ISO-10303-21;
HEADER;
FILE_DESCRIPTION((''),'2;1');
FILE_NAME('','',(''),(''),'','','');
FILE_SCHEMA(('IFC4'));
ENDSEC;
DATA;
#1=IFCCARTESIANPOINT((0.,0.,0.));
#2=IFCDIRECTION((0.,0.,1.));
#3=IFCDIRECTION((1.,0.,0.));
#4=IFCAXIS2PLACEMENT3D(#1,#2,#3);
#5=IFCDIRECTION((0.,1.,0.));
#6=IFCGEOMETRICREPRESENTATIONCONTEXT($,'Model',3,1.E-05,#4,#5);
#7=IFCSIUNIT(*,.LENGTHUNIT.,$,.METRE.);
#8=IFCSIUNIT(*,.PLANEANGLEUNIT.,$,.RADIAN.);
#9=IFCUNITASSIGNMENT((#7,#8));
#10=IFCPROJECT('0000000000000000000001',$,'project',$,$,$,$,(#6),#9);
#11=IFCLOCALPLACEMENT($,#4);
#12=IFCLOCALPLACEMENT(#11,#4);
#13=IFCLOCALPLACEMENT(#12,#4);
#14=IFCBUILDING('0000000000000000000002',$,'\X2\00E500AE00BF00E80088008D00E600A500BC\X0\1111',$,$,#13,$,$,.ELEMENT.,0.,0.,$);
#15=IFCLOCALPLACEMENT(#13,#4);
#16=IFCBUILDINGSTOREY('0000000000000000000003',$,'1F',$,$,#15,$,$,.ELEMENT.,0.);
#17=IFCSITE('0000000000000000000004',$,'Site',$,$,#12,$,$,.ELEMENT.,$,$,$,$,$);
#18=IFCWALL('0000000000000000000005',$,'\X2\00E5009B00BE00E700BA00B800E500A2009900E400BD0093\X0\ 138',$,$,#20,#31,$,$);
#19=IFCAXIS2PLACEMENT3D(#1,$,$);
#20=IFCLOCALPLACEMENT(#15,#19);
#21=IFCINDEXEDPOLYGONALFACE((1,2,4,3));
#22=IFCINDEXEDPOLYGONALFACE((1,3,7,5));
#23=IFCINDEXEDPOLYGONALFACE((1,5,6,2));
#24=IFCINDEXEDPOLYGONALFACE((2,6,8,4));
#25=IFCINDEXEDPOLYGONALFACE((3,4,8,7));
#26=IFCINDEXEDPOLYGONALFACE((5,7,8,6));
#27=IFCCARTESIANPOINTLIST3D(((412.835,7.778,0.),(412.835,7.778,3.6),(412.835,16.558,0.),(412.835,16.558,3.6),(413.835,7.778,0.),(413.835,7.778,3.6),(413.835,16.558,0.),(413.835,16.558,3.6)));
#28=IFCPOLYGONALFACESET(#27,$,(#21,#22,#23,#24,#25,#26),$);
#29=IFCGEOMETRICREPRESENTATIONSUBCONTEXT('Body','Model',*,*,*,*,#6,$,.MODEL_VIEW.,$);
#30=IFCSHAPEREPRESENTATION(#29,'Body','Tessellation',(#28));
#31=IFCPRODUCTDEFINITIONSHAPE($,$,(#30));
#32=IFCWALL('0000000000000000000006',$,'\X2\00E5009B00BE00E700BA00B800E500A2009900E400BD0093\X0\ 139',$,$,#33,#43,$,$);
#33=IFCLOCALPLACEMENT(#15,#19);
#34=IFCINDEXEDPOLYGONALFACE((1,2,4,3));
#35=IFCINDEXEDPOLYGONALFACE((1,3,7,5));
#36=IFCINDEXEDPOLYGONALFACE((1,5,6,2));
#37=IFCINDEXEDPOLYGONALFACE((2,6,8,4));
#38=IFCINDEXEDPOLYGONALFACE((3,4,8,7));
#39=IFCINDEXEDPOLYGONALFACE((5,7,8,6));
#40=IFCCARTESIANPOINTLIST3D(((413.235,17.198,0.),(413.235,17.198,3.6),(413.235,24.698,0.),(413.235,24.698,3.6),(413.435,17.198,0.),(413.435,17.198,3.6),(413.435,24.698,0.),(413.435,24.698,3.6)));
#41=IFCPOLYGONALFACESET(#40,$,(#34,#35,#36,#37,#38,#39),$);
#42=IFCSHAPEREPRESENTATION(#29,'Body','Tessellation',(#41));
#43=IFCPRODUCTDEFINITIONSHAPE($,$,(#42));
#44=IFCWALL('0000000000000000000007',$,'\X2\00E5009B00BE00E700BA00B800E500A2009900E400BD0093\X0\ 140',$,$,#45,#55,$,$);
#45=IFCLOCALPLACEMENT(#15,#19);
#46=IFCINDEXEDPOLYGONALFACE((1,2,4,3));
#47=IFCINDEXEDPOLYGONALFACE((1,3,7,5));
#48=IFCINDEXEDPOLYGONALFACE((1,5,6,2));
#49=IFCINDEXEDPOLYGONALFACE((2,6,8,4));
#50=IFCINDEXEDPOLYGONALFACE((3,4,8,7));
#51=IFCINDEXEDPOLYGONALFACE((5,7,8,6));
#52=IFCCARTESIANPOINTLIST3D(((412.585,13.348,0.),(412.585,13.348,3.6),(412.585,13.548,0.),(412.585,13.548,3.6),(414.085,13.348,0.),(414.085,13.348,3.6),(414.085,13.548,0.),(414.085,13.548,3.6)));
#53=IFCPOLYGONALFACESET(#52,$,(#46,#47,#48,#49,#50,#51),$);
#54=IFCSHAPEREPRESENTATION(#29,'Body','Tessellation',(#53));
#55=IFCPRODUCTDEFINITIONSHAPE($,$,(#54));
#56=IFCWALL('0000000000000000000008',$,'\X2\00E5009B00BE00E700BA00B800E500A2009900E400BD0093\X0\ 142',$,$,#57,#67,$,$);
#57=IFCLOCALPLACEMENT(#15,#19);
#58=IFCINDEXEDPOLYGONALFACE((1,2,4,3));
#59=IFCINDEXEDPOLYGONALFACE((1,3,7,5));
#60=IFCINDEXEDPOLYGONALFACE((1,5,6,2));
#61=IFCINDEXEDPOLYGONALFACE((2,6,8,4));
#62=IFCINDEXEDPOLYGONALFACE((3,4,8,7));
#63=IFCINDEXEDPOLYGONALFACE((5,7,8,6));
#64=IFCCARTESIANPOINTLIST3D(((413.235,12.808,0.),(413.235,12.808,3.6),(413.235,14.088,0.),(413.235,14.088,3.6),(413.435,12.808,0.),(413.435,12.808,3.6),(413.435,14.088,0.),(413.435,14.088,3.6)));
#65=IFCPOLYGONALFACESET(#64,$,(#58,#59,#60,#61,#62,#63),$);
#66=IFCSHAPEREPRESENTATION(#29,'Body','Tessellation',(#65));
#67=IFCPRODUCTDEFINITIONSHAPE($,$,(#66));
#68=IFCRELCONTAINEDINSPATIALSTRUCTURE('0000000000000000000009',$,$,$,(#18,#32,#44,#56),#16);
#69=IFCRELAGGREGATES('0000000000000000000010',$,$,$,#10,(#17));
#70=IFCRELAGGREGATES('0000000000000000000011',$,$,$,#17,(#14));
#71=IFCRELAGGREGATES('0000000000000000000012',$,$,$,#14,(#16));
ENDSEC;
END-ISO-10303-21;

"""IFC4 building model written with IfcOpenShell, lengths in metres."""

from ifc_helpers import new_model, si_unit, direction, frame, frame_2d, origin_with_axes, place, context, subcontext, project, spatial, rectangle, extrude, element, save


model = new_model("IFC4")

# Units and contexts
model_context = context("Model", 3, precision=1e-05, world=origin_with_axes(), true_north=direction((0.0, 1.0, 0.0)))
body_context = subcontext(model_context, "Body", "Model", "MODEL_VIEW")
ifc_project = project(units=[si_unit("LENGTHUNIT", "METRE"), si_unit("PLANEANGLEUNIT", "RADIAN")], contexts=[model_context])

# Site, building, storey
placement = place(None, origin_with_axes())
site_placement = place(placement, origin_with_axes())
site = spatial("IfcSite", under=ifc_project, at=site_placement, Name="Site", CompositionType="ELEMENT")
building_placement = place(site_placement, origin_with_axes())
building = spatial("IfcBuilding", under=site, at=building_placement, Name="å®¿è\u0088\u008dæ¥¼1111", CompositionType="ELEMENT", ElevationOfRefHeight=0.0, ElevationOfTerrain=0.0)
storey_placement = place(building_placement, origin_with_axes())
storey = spatial("IfcBuildingStorey", under=building, at=storey_placement, Name="1F", CompositionType="ELEMENT", Elevation=0.0)

# Walls
wall_1_placement = place(storey_placement, frame((413.335, 12.168, 0.0), z_axis=(0.0, 0.0, 1.0), x_axis=(1.0, 0.0, 0.0)))
element("IfcWall", 1, at=wall_1_placement, inside=storey, Name="å\u009b¾çº¸å¢\u0099ä½\u0093 138", context=body_context, shape_type="SweptSolid", body=[
    extrude(rectangle(XDim=1.0, YDim=8.78, at=frame_2d((0.0, 0.0), x_axis=(1.0, 0.0, 0.0))), frame((0.0, 0.0, 0.0), z_axis=(0.0, 0.0, 1.0)), (0.0, 0.0, 1.0), 3.6),
])
wall_2_placement = place(storey_placement, frame((413.335, 20.948, 0.0), z_axis=(0.0, 0.0, 1.0), x_axis=(0.0, -1.0, 0.0)))
element("IfcWall", 2, at=wall_2_placement, inside=storey, Name="å\u009b¾çº¸å¢\u0099ä½\u0093 139", context=body_context, shape_type="SweptSolid", body=[
    extrude(rectangle(XDim=7.5, YDim=0.2, at=frame_2d((0.0, 0.0), x_axis=(1.0, 0.0, 0.0))), frame((0.0, 0.0, 0.0), z_axis=(0.0, 0.0, 1.0)), (0.0, 0.0, 1.0), 3.6),
])
wall_3_placement = place(storey_placement, frame((413.335, 13.448, 0.0), z_axis=(0.0, 0.0, 1.0), x_axis=(1.0, 0.0, 0.0)))
element("IfcWall", 3, at=wall_3_placement, inside=storey, Name="å\u009b¾çº¸å¢\u0099ä½\u0093 140", context=body_context, shape_type="SweptSolid", body=[
    extrude(rectangle(XDim=1.5, YDim=0.2, at=frame_2d((0.0, 0.0), x_axis=(1.0, 0.0, 0.0))), frame((0.0, 0.0, 0.0), z_axis=(0.0, 0.0, 1.0)), (0.0, 0.0, 1.0), 3.6),
])
wall_4_placement = place(storey_placement, frame((413.335, 13.448, 0.0), z_axis=(0.0, 0.0, 1.0), x_axis=(0.0, -1.0, 0.0)))
element("IfcWall", 4, at=wall_4_placement, inside=storey, Name="å\u009b¾çº¸å¢\u0099ä½\u0093 142", context=body_context, shape_type="SweptSolid", body=[
    extrude(rectangle(XDim=1.28, YDim=0.2, at=frame_2d((0.0, 0.0), x_axis=(1.0, 0.0, 0.0))), frame((0.0, 0.0, 0.0), z_axis=(0.0, 0.0, 1.0)), (0.0, 0.0, 1.0), 3.6),
])

save(model, "model.ifc")
